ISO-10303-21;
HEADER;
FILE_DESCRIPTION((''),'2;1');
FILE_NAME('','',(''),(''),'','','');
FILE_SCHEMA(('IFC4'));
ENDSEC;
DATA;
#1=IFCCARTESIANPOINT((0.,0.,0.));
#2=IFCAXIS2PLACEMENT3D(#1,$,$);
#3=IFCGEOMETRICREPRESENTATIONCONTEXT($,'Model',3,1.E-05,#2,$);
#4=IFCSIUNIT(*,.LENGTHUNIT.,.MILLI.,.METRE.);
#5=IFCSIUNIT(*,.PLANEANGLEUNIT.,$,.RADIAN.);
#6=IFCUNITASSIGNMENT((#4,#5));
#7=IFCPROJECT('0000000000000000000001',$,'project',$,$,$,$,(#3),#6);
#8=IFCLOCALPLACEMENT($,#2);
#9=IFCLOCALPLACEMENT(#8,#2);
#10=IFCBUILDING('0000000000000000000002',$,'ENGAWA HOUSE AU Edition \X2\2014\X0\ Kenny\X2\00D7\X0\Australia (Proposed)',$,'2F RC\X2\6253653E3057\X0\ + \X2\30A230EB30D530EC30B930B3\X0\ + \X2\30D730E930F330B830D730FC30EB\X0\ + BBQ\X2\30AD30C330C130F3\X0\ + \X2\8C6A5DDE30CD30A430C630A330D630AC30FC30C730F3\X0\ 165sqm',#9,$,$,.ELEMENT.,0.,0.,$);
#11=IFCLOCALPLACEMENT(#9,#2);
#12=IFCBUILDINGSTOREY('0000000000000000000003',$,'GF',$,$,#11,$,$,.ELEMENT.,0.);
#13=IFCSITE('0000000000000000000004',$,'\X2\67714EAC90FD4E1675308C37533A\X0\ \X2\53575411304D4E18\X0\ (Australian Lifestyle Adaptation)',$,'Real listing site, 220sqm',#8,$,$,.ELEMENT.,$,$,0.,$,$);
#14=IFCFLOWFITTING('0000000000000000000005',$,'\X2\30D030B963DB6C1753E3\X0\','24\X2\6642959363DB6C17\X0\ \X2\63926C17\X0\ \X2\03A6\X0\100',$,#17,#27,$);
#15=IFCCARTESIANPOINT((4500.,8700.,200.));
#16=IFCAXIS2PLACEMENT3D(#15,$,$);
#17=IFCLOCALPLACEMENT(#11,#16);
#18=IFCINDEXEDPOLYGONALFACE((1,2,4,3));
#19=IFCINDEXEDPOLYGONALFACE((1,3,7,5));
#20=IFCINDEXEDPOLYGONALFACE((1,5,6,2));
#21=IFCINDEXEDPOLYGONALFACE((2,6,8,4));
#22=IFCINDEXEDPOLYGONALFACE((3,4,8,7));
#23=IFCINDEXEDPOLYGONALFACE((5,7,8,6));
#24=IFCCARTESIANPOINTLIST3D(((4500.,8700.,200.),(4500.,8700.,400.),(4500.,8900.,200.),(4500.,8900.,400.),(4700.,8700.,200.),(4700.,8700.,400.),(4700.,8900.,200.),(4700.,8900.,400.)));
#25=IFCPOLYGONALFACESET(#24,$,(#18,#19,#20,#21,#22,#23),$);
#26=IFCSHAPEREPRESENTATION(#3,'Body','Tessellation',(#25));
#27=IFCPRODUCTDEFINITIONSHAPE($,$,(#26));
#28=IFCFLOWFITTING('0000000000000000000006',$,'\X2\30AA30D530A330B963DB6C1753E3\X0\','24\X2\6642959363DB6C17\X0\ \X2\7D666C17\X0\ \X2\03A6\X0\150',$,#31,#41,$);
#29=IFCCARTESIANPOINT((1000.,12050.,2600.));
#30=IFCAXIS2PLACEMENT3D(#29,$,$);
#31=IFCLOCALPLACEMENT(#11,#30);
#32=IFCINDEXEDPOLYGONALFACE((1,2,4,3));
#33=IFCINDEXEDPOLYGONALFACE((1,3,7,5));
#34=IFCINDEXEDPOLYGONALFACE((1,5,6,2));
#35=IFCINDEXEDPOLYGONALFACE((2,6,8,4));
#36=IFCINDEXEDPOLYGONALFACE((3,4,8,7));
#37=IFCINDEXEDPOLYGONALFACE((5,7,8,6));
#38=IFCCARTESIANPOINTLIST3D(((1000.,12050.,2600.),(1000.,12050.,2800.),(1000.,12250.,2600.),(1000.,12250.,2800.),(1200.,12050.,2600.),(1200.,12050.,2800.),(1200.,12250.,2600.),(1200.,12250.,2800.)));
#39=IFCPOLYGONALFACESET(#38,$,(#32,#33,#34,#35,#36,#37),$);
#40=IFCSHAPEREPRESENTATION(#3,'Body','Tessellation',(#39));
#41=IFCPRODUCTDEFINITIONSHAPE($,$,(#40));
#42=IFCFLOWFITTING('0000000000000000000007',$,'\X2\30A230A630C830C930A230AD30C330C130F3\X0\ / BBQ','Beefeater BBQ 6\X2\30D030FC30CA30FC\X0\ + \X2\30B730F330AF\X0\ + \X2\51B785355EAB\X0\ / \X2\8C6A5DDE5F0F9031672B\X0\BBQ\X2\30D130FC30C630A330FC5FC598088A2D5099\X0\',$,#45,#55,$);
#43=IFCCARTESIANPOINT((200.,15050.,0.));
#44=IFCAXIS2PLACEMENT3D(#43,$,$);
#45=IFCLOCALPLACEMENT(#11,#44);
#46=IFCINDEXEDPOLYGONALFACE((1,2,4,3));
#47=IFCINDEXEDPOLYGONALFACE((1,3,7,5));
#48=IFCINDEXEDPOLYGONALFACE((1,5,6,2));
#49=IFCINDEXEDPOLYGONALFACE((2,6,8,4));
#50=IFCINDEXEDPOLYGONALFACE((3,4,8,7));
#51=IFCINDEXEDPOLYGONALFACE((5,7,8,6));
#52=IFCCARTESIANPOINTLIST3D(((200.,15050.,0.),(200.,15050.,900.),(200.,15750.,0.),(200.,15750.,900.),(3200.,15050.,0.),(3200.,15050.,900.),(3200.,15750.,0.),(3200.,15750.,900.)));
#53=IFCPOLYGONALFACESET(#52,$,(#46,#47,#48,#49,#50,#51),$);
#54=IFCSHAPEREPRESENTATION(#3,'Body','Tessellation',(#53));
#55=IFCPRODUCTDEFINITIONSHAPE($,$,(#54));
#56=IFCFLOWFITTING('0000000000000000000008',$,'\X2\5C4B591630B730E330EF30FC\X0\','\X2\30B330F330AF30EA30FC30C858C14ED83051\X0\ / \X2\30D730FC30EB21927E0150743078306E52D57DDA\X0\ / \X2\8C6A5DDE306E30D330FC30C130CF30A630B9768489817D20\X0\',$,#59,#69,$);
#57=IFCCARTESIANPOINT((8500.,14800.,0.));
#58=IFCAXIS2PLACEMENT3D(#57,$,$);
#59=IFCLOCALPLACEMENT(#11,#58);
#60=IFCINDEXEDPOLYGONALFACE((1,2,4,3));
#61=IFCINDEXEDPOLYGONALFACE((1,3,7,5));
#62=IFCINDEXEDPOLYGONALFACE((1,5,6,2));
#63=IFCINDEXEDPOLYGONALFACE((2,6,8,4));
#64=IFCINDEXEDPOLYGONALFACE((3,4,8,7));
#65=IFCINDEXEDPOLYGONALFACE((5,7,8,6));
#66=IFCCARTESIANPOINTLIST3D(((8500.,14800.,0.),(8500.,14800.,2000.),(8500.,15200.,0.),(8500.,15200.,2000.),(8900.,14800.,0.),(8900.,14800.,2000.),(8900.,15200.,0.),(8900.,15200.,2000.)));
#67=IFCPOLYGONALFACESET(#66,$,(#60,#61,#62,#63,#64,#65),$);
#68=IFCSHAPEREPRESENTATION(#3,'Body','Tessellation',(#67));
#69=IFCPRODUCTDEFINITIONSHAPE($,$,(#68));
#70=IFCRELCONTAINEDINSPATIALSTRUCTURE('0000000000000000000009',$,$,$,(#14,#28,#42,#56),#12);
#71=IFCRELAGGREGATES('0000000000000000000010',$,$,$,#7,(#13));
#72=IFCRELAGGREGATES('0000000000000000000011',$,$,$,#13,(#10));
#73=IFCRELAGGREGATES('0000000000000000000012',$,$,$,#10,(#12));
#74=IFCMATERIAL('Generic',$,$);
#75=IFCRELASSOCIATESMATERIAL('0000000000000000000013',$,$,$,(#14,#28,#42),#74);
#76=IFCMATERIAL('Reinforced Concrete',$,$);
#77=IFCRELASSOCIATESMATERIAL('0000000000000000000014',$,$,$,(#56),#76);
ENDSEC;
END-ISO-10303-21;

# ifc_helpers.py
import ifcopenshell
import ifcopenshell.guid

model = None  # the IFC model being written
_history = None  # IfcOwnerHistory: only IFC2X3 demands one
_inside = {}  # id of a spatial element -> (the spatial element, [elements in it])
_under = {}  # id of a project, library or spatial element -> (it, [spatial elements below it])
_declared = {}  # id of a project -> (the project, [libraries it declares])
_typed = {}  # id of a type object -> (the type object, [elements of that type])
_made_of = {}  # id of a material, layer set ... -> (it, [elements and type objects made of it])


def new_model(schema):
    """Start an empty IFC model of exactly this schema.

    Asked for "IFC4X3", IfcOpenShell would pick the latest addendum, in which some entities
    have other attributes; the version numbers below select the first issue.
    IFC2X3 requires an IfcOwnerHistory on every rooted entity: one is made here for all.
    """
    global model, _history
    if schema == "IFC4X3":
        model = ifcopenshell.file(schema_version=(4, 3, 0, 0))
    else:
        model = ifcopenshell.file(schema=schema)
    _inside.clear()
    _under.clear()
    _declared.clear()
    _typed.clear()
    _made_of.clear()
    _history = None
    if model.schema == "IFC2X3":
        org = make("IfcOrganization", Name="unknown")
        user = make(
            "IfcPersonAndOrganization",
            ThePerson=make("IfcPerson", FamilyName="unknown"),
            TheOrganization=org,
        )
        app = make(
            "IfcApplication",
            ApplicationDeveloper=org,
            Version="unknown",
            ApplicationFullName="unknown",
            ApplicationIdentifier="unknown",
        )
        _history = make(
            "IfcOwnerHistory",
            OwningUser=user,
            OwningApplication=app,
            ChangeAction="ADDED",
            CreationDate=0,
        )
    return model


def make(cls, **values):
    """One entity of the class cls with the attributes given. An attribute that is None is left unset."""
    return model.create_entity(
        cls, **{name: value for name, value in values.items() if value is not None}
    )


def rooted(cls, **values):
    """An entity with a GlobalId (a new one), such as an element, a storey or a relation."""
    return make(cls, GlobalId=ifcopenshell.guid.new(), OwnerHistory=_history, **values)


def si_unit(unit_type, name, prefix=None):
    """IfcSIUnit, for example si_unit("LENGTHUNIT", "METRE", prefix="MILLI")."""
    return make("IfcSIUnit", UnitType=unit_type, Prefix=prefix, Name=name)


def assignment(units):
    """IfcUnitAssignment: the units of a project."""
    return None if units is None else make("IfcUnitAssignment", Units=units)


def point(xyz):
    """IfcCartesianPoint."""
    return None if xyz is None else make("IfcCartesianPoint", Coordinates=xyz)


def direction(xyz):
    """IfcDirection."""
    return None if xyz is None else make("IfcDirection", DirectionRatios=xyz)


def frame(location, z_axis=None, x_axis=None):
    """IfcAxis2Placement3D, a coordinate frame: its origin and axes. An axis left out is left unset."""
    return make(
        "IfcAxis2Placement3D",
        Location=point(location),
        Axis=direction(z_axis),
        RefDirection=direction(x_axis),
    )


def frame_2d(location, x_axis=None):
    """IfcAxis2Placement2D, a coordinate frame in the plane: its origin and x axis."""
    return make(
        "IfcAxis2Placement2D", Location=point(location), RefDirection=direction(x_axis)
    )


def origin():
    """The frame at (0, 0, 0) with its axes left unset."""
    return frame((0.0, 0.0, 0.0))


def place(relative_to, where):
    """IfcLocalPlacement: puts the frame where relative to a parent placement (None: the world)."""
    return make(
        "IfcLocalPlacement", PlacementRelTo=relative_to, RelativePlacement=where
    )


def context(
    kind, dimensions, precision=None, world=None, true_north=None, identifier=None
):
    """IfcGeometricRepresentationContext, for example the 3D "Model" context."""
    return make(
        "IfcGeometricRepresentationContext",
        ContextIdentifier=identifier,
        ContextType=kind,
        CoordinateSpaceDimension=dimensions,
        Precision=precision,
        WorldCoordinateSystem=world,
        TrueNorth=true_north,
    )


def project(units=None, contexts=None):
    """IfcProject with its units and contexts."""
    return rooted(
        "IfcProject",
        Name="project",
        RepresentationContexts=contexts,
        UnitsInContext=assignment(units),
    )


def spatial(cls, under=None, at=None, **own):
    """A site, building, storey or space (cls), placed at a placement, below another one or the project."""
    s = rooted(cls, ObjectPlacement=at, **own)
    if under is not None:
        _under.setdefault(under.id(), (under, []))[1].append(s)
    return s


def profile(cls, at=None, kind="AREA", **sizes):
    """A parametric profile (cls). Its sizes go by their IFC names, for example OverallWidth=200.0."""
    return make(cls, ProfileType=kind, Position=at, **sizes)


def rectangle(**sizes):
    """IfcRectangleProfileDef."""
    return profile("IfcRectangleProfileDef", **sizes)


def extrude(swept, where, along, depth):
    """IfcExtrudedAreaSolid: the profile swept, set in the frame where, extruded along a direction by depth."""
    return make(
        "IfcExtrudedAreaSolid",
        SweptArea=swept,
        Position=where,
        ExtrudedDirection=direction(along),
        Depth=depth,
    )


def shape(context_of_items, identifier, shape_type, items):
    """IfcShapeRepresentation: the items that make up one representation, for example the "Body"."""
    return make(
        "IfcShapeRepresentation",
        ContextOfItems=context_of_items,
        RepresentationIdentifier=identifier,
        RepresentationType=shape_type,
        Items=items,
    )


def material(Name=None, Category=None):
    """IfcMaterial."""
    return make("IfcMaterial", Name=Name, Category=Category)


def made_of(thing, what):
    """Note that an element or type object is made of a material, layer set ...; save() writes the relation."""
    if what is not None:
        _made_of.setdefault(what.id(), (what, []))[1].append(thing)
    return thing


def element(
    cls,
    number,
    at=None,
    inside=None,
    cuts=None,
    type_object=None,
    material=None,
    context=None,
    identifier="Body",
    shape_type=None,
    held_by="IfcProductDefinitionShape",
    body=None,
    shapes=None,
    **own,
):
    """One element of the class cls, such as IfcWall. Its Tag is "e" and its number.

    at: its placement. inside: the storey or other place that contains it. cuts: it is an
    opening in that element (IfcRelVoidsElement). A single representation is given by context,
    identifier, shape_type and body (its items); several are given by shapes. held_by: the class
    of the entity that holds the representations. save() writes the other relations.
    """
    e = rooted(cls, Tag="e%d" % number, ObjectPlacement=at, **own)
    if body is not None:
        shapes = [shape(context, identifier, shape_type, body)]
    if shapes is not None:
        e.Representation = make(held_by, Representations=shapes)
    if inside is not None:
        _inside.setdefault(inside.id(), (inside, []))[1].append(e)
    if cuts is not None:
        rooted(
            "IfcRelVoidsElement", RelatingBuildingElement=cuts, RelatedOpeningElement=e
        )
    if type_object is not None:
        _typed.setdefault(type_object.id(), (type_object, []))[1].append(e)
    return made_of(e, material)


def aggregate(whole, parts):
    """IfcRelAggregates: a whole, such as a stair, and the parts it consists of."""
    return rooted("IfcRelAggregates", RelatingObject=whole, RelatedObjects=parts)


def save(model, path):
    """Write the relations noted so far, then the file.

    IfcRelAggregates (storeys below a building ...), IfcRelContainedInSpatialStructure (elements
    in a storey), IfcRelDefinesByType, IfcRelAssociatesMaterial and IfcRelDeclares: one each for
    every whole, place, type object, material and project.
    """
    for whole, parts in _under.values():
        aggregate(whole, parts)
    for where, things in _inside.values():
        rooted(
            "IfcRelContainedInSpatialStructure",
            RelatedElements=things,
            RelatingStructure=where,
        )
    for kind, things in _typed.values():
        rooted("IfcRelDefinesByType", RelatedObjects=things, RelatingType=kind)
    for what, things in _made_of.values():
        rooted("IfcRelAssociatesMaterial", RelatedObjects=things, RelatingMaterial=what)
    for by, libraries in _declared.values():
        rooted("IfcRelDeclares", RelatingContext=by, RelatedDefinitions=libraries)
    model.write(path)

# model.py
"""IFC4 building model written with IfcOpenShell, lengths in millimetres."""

from ifc_helpers import new_model, si_unit, frame, frame_2d, origin, place, context, project, spatial, rectangle, extrude, material, element, save


model = new_model("IFC4")

# Units and contexts
model_context = context("Model", 3, precision=1e-05, world=origin())
ifc_project = project(units=[si_unit("LENGTHUNIT", "METRE", prefix="MILLI"), si_unit("PLANEANGLEUNIT", "RADIAN")], contexts=[model_context])

# Site, building, storey
site_placement = place(None, origin())
site = spatial("IfcSite", under=ifc_project, at=site_placement, Name="東京都世田谷区 南向き丘 (Australian Lifestyle Adaptation)", ObjectType="Real listing site, 220sqm", CompositionType="ELEMENT", RefElevation=0.0)
building_placement = place(site_placement, origin())
building = spatial("IfcBuilding", under=site, at=building_placement, Name="ENGAWA HOUSE AU Edition — Kenny×Australia (Proposed)", ObjectType="2F RC打放し + アルフレスコ + プランジプール + BBQキッチン + 豪州ネイティブガーデン 165sqm", CompositionType="ELEMENT", ElevationOfRefHeight=0.0, ElevationOfTerrain=0.0)
storey_placement = place(building_placement, origin())
storey = spatial("IfcBuildingStorey", under=building, at=storey_placement, Name="GF", CompositionType="ELEMENT", Elevation=0.0)

# Shared definitions
ifc_material_1 = material(Name="Generic")

# Shared definitions
ifc_material_2 = material(Name="Reinforced Concrete")

# Flow fittings
flow_fitting_1_placement = place(storey_placement, frame((4500.0, 8700.0, 200.0)))
element("IfcFlowFitting", 1, at=flow_fitting_1_placement, inside=storey, material=ifc_material_1, Name="バス換気口", Description="24時間換気 排気 Φ100", context=model_context, shape_type="SweptSolid", body=[
    extrude(rectangle(XDim=200.0, YDim=200.0, at=frame_2d((100.0, 100.0))), frame((4500.0, 8700.0, 200.0)), (0.0, 0.0, 1.0), 200.0),
])
flow_fitting_2_placement = place(storey_placement, frame((1000.0, 12050.0, 2600.0)))
element("IfcFlowFitting", 2, at=flow_fitting_2_placement, inside=storey, material=ifc_material_1, Name="オフィス換気口", Description="24時間換気 給気 Φ150", context=model_context, shape_type="SweptSolid", body=[
    extrude(rectangle(XDim=200.0, YDim=200.0, at=frame_2d((100.0, 100.0))), frame((1000.0, 12050.0, 2600.0)), (0.0, 0.0, 1.0), 200.0),
])
flow_fitting_3_placement = place(storey_placement, frame((200.0, 15050.0, 0.0)))
element("IfcFlowFitting", 3, at=flow_fitting_3_placement, inside=storey, material=ifc_material_1, Name="アウトドアキッチン / BBQ", Description="Beefeater BBQ 6バーナー + シンク + 冷蔵庫 / 豪州式週末BBQパーティー必須設備", context=model_context, shape_type="SweptSolid", body=[
    extrude(rectangle(XDim=3000.0, YDim=700.0, at=frame_2d((1500.0, 350.0))), frame((200.0, 15050.0, 0.0)), (0.0, 0.0, 1.0), 900.0),
])
flow_fitting_4_placement = place(storey_placement, frame((8500.0, 14800.0, 0.0)))
element("IfcFlowFitting", 4, at=flow_fitting_4_placement, inside=storey, material=ifc_material_2, Name="屋外シャワー", Description="コンクリート壁付け / プール→縁側への動線 / 豪州のビーチハウス的要素", context=model_context, shape_type="SweptSolid", body=[
    extrude(rectangle(XDim=400.0, YDim=400.0, at=frame_2d((200.0, 200.0))), frame((8500.0, 14800.0, 0.0)), (0.0, 0.0, 1.0), 2000.0),
])

save(model, "model.ifc")
